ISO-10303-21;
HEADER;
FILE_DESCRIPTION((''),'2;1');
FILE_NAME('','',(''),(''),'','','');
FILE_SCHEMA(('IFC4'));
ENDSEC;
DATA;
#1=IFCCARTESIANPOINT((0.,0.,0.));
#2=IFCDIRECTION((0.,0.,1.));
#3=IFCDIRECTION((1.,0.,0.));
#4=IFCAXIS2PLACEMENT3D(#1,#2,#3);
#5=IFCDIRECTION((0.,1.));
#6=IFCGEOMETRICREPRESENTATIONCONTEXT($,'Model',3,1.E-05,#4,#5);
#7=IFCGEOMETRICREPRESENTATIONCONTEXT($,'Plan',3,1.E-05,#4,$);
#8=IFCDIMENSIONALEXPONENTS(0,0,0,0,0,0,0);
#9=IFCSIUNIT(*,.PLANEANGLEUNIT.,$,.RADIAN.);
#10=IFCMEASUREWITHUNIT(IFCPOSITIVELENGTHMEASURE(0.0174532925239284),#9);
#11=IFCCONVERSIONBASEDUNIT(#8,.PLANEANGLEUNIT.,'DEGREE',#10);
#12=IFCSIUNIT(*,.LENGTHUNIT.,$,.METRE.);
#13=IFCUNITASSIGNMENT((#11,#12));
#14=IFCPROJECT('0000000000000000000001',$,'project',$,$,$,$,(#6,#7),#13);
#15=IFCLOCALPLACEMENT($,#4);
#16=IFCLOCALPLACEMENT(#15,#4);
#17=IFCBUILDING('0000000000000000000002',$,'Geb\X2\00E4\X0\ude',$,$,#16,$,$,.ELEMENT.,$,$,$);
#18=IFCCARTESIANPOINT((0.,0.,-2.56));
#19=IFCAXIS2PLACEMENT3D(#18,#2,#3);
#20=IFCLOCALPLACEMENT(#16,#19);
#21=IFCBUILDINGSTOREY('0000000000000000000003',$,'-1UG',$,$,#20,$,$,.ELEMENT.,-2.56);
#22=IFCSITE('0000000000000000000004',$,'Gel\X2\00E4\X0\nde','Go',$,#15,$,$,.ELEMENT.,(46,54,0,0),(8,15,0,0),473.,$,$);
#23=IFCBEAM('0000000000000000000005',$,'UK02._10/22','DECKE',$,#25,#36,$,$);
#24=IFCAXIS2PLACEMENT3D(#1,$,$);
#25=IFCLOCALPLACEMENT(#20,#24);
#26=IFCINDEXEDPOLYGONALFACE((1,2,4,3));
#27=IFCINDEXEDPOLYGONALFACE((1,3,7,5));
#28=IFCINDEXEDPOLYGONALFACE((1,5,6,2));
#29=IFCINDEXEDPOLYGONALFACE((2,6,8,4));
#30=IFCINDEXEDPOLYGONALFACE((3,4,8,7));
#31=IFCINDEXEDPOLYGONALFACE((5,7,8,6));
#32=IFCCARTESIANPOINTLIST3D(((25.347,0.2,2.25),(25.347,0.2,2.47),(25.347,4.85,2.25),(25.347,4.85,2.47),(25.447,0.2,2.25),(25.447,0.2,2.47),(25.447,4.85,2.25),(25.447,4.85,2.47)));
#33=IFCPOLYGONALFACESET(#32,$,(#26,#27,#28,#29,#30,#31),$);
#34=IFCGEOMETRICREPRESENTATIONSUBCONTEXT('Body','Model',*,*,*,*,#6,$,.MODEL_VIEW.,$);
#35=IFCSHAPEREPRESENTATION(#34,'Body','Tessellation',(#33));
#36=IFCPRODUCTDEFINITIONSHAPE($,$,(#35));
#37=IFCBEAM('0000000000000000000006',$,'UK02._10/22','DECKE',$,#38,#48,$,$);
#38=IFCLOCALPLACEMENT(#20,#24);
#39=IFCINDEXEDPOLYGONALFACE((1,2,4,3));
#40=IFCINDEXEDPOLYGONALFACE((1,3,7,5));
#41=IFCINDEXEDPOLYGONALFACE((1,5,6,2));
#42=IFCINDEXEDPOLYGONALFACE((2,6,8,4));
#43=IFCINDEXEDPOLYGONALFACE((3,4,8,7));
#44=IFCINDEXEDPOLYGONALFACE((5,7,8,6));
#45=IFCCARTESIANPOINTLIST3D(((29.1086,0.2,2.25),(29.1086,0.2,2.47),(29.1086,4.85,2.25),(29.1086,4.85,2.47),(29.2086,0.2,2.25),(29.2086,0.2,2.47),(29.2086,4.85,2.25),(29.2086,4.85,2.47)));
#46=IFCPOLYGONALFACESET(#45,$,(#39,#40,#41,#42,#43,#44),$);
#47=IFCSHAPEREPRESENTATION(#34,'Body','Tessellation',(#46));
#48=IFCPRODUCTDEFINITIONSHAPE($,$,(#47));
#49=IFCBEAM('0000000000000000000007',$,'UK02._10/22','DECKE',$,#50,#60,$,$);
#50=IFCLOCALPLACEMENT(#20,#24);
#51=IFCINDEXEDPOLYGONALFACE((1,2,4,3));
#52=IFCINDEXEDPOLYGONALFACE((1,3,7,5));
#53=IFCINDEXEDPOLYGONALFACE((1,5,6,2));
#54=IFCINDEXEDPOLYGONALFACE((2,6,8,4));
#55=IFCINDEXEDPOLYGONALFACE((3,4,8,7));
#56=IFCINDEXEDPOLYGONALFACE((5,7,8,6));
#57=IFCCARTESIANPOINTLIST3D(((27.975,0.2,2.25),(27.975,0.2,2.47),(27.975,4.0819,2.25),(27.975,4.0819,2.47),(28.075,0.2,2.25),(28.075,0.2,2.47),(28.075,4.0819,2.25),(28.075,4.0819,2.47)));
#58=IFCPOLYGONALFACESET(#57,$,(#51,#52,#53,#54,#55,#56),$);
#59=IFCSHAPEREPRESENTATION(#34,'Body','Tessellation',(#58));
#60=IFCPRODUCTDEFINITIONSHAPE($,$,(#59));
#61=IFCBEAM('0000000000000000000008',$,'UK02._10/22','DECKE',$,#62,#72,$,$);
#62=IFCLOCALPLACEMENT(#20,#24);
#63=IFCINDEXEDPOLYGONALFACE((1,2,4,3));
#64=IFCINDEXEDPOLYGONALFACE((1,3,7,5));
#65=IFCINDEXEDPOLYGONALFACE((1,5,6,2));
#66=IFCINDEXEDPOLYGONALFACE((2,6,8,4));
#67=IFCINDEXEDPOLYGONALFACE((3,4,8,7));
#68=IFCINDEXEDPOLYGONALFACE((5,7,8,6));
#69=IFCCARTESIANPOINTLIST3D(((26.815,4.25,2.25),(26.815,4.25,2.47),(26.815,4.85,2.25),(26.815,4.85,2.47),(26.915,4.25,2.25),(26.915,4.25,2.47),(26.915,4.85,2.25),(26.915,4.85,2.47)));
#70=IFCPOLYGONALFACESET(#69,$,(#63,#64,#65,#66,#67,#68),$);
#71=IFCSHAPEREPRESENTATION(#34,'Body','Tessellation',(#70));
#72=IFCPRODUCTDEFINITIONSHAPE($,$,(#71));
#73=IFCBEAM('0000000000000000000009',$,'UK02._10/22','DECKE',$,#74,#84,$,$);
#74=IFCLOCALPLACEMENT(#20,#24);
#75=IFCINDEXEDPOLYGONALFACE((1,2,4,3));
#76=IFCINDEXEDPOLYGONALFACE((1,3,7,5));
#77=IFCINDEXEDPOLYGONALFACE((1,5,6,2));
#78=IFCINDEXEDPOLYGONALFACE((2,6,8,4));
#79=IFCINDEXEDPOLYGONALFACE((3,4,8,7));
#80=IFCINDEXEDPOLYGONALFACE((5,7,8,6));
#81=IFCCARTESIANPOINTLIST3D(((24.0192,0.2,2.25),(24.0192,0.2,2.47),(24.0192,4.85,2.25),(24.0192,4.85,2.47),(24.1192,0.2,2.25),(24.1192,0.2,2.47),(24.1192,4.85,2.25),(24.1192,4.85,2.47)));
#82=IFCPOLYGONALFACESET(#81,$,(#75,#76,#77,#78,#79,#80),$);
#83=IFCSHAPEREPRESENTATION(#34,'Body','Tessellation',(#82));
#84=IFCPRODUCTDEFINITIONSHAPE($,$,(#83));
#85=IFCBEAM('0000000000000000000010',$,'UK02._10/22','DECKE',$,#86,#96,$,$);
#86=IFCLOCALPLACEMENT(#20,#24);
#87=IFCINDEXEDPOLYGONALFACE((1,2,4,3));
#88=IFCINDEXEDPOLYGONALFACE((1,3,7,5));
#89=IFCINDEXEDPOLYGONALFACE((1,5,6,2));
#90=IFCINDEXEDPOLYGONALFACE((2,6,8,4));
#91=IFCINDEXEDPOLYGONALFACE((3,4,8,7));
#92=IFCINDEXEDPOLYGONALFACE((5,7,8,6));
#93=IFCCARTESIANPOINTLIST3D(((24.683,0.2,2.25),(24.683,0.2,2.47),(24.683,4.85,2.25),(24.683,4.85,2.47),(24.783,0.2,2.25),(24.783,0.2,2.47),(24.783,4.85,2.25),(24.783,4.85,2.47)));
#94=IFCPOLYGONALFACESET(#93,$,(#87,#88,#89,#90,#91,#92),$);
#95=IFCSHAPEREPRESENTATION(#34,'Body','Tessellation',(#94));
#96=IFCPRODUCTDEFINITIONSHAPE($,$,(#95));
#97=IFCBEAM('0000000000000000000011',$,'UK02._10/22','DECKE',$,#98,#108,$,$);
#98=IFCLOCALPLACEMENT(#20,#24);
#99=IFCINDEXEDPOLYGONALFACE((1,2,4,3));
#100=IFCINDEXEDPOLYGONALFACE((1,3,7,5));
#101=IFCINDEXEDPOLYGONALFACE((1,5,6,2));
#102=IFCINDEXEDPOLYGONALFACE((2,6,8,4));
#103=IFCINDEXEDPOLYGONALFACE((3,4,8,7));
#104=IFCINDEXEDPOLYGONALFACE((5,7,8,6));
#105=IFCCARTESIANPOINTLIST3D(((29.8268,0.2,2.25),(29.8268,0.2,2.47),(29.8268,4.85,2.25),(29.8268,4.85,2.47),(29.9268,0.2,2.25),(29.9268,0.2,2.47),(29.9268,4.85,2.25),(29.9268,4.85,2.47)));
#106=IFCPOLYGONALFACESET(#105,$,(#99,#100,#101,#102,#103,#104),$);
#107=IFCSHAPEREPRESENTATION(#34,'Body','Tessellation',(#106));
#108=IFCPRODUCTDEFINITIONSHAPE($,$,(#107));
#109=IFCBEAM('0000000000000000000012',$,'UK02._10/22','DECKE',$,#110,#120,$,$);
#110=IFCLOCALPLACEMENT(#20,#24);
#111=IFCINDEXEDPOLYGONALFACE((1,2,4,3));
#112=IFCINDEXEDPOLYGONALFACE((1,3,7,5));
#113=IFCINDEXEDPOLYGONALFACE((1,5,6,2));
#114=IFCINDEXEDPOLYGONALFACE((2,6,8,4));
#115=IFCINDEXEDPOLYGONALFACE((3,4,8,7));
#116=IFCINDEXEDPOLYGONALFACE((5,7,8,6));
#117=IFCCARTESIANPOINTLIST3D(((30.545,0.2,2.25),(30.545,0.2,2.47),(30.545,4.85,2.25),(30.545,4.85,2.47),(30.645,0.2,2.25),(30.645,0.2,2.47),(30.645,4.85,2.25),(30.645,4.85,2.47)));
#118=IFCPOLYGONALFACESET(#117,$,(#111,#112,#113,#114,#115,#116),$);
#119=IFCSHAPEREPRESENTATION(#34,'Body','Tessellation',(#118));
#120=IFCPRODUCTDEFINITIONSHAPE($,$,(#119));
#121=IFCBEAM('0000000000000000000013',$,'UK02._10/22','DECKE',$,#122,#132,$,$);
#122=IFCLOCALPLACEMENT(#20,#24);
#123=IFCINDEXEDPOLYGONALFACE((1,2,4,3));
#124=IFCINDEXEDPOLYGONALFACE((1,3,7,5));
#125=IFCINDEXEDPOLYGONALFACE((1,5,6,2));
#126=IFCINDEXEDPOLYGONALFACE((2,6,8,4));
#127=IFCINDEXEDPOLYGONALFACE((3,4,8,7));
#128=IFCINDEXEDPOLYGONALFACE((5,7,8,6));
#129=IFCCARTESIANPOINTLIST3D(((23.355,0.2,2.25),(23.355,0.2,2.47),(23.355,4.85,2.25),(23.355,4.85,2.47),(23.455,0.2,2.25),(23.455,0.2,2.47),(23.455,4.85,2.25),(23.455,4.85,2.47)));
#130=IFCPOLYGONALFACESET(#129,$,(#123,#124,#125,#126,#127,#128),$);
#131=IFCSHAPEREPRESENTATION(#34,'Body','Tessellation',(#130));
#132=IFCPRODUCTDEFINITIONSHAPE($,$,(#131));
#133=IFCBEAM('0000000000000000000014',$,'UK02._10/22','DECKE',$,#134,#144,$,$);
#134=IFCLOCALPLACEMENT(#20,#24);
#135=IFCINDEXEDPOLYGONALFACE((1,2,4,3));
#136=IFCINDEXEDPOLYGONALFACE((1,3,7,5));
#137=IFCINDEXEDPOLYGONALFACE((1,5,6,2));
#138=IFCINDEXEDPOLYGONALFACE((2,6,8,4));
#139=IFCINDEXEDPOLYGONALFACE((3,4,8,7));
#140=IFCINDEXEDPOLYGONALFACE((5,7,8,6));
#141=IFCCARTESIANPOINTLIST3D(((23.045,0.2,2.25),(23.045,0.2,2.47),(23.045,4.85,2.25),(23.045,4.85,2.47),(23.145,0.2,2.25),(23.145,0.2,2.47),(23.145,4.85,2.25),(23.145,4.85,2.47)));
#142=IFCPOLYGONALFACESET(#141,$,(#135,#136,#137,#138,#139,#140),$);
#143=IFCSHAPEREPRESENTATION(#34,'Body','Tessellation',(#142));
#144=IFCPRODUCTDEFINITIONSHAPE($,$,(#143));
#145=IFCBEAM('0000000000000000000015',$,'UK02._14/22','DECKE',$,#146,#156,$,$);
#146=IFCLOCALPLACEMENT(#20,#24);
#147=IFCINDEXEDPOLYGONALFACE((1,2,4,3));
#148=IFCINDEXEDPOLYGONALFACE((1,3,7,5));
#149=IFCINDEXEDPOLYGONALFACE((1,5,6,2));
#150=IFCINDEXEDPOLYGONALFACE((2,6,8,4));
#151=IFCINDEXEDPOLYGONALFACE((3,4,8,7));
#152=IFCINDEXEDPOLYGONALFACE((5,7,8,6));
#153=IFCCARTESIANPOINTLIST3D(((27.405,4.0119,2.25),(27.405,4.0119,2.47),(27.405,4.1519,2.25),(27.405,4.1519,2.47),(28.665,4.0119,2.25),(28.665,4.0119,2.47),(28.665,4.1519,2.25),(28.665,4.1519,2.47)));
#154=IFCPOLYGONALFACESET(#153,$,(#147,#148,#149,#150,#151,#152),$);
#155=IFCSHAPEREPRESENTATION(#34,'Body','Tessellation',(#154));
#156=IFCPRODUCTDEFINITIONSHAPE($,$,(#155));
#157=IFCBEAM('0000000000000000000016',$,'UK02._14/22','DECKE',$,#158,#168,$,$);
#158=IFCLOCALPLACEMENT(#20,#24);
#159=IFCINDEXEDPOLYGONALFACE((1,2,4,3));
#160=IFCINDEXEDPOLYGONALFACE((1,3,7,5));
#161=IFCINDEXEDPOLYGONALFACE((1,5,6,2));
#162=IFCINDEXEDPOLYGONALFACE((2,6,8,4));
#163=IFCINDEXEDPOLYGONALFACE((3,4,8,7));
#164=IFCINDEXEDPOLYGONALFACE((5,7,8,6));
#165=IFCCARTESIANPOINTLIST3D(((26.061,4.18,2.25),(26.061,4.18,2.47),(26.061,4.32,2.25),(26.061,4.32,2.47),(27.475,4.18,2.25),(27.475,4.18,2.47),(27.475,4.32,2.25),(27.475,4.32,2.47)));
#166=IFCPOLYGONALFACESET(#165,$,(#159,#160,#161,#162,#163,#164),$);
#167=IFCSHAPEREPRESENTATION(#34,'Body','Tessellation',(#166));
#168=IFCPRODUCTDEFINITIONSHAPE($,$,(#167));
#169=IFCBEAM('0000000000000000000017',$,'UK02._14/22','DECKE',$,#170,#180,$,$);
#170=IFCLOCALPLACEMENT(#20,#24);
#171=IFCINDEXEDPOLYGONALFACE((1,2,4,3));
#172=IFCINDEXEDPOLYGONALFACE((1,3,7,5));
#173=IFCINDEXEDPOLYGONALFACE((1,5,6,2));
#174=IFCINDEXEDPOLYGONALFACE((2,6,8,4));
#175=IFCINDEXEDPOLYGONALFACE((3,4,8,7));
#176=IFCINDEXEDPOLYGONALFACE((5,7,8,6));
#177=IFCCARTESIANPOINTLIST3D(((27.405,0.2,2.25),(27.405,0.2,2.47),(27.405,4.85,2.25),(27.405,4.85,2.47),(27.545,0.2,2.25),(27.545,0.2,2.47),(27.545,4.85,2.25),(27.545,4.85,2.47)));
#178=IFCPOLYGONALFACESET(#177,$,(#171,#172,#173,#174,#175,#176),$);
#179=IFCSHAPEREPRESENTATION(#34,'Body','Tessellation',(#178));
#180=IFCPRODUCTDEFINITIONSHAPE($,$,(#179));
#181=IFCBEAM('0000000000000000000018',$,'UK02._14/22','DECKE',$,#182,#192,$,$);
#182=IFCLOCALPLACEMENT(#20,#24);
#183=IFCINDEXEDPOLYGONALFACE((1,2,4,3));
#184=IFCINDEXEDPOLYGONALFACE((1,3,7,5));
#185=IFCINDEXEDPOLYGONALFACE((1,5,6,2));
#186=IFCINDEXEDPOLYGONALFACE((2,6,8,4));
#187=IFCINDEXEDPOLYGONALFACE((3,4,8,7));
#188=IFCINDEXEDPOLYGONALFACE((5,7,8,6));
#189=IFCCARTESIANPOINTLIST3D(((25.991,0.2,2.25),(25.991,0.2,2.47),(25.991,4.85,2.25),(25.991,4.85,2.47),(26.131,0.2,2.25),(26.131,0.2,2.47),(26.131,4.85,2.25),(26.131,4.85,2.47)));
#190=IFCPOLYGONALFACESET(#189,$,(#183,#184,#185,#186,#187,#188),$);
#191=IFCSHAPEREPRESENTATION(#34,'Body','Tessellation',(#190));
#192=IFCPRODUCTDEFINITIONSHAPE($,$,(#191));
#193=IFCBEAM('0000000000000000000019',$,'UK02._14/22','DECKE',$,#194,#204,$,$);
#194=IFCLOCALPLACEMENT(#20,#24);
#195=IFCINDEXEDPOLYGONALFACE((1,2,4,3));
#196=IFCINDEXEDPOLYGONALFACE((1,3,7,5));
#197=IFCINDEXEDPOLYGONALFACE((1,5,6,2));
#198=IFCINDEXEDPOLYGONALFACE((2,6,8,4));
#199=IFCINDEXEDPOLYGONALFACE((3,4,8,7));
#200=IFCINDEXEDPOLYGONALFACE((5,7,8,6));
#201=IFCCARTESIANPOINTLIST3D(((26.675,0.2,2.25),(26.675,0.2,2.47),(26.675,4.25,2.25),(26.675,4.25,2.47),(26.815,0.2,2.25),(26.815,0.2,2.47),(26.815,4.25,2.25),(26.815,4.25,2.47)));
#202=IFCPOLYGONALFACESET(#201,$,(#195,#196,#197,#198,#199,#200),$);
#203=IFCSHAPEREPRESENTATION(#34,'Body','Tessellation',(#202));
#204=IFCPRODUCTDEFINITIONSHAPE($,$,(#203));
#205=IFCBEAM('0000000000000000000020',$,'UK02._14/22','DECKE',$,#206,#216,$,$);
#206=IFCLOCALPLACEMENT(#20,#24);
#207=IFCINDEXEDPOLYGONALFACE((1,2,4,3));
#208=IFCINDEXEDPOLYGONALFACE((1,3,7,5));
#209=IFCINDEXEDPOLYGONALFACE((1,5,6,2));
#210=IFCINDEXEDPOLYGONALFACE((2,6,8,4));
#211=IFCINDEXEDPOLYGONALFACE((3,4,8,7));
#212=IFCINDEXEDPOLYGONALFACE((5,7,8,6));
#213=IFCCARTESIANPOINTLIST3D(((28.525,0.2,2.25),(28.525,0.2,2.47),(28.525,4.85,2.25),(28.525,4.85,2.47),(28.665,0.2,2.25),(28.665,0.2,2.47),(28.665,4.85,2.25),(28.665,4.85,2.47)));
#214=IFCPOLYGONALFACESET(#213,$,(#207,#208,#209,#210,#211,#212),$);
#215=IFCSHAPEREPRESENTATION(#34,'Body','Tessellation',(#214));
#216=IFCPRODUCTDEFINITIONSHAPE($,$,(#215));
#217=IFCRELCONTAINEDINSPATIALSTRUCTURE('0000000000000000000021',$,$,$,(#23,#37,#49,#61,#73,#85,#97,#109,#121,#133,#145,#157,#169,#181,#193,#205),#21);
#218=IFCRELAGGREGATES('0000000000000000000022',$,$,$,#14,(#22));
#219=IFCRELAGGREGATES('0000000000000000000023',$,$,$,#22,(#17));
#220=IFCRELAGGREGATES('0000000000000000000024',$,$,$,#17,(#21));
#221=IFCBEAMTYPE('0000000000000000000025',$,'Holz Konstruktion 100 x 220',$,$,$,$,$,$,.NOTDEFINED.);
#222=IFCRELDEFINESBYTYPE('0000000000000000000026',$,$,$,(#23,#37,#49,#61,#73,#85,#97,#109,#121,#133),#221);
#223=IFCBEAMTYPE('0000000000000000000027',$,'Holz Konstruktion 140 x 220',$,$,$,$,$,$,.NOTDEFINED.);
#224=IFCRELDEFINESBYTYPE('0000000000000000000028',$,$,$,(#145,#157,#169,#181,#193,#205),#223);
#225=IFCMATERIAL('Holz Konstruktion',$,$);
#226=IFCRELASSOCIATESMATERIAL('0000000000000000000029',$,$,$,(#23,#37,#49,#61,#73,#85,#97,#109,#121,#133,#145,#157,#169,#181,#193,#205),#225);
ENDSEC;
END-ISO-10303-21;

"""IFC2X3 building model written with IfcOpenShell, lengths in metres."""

from ifc_helpers import new_model, entity, si_unit, converted_unit, direction, frame, frame_2d, origin_with_axes, place, context, subcontext, project, spatial, rectangle, extrude, material, type_object, element, save


model = new_model("IFC2X3")

# Units and contexts
model_context = context("Model", 3, precision=1e-05, world=origin_with_axes(), true_north=direction((0.0, 1.0)))
plan_context = context("Plan", 3, precision=1e-05, world=origin_with_axes())
body_context = subcontext(model_context, "Body", "Model", "MODEL_VIEW")
ifc_project = project(units=[converted_unit("PLANEANGLEUNIT", "DEGREE", entity("IfcPositiveLengthMeasure", 0.0174532925239284), si_unit("PLANEANGLEUNIT", "RADIAN"), dimensions=[0, 0, 0, 0, 0, 0, 0]), si_unit("LENGTHUNIT", "METRE")], contexts=[model_context, plan_context])

# Site, building, storey
site_placement = place(None, origin_with_axes())
site = spatial("IfcSite", under=ifc_project, at=site_placement, Name="Gelände", Description="Go", CompositionType="ELEMENT", RefLatitude=(46, 54, 0, 0), RefLongitude=(8, 15, 0, 0), RefElevation=473.0)
building_placement = place(site_placement, origin_with_axes())
building = spatial("IfcBuilding", under=site, at=building_placement, Name="Gebäude", CompositionType="ELEMENT")
storey_placement = place(building_placement, frame((0.0, 0.0, -2.56), z_axis=(0.0, 0.0, 1.0), x_axis=(1.0, 0.0, 0.0)))
storey = spatial("IfcBuildingStorey", under=building, at=storey_placement, Name="-1UG", CompositionType="ELEMENT", Elevation=-2.56)

# Beams
ifc_material_1 = material(Name="Holz Konstruktion")
beam_type_1 = type_object("IfcBeamType", Name="Holz Konstruktion 100 x 220", PredefinedType="NOTDEFINED")
for number, where, z_axis, x_axis, name in (
    (1, (25.397, 0.2, 2.47), (0.0, 0.0, 1.0), (1.0, 0.0, 0.0), "UK02._10/22"),
    (2, (29.1586, 0.2, 2.47), (0.0, 0.0, 1.0), (1.0, 0.0, 0.0), "UK02._10/22"),
):
    element("IfcBeam", number, at=place(storey_placement, frame(where, z_axis=z_axis, x_axis=x_axis)), inside=storey, type_object=beam_type_1, material=ifc_material_1, Name=name, Description="DECKE", context=body_context, shape_type="SweptSolid", body=[
        extrude(rectangle(XDim=0.22, YDim=0.1, at=frame_2d((-0.11, 0.0), x_axis=(1.0, 0.0))), frame((0.0, 0.0, 0.0), z_axis=(0.0, 1.0, 0.0), x_axis=(0.0, 0.0, 1.0)), (0.0, 0.0, 1.0), 4.65),
    ])
beam_1_placement = place(storey_placement, frame((28.025, 0.2, 2.47), z_axis=(0.0, 0.0, 1.0), x_axis=(1.0, 0.0, 0.0)))
element("IfcBeam", 3, at=beam_1_placement, inside=storey, type_object=beam_type_1, material=ifc_material_1, Name="UK02._10/22", Description="DECKE", context=body_context, shape_type="SweptSolid", body=[
    extrude(rectangle(XDim=0.22, YDim=0.1, at=frame_2d((-0.11, 0.0), x_axis=(1.0, 0.0))), frame((0.0, 0.0, 0.0), z_axis=(0.0, 1.0, 0.0), x_axis=(0.0, 0.0, 1.0)), (0.0, 0.0, 1.0), 3.8819),
])
beam_2_placement = place(storey_placement, frame((26.865, 4.25, 2.47), z_axis=(0.0, 0.0, 1.0), x_axis=(1.0, 0.0, 0.0)))
element("IfcBeam", 4, at=beam_2_placement, inside=storey, type_object=beam_type_1, material=ifc_material_1, Name="UK02._10/22", Description="DECKE", context=body_context, shape_type="SweptSolid", body=[
    extrude(rectangle(XDim=0.22, YDim=0.1, at=frame_2d((-0.11, 0.0), x_axis=(1.0, 0.0))), frame((0.0, 0.0, 0.0), z_axis=(0.0, 1.0, 0.0), x_axis=(0.0, 0.0, 1.0)), (0.0, 0.0, 1.0), 0.6),
])
for number, where, z_axis, x_axis, name in (
    (5, (24.0692, 0.2, 2.47), (0.0, 0.0, 1.0), (1.0, 0.0, 0.0), "UK02._10/22"),
    (6, (24.733, 0.2, 2.47), (0.0, 0.0, 1.0), (1.0, 0.0, 0.0), "UK02._10/22"),
    (7, (29.8768, 0.2, 2.47), (0.0, 0.0, 1.0), (1.0, 0.0, 0.0), "UK02._10/22"),
    (8, (30.595, 0.2, 2.47), (0.0, 0.0, 1.0), (1.0, 0.0, 0.0), "UK02._10/22"),
    (9, (23.405, 0.2, 2.47), (0.0, 0.0, 1.0), (1.0, 0.0, 0.0), "UK02._10/22"),
    (10, (23.095, 0.2, 2.47), (0.0, 0.0, 1.0), (1.0, 0.0, 0.0), "UK02._10/22"),
):
    element("IfcBeam", number, at=place(storey_placement, frame(where, z_axis=z_axis, x_axis=x_axis)), inside=storey, type_object=beam_type_1, material=ifc_material_1, Name=name, Description="DECKE", context=body_context, shape_type="SweptSolid", body=[
        extrude(rectangle(XDim=0.22, YDim=0.1, at=frame_2d((-0.11, 0.0), x_axis=(1.0, 0.0))), frame((0.0, 0.0, 0.0), z_axis=(0.0, 1.0, 0.0), x_axis=(0.0, 0.0, 1.0)), (0.0, 0.0, 1.0), 4.65),
    ])
beam_type_2 = type_object("IfcBeamType", Name="Holz Konstruktion 140 x 220", PredefinedType="NOTDEFINED")
beam_3_placement = place(storey_placement, frame((28.665, 4.0819, 2.47), z_axis=(0.0, 0.0, 1.0), x_axis=(0.0, 1.0, 0.0)))
element("IfcBeam", 11, at=beam_3_placement, inside=storey, type_object=beam_type_2, material=ifc_material_1, Name="UK02._14/22", Description="DECKE", context=body_context, shape_type="SweptSolid", body=[
    extrude(rectangle(XDim=0.22, YDim=0.14, at=frame_2d((-0.11, 0.0), x_axis=(1.0, 0.0))), frame((0.0, 0.0, 0.0), z_axis=(0.0, 1.0, 0.0), x_axis=(0.0, 0.0, 1.0)), (0.0, 0.0, 1.0), 1.26),
])
beam_4_placement = place(storey_placement, frame((27.475, 4.25, 2.47), z_axis=(0.0, 0.0, 1.0), x_axis=(0.0, 1.0, 0.0)))
element("IfcBeam", 12, at=beam_4_placement, inside=storey, type_object=beam_type_2, material=ifc_material_1, Name="UK02._14/22", Description="DECKE", context=body_context, shape_type="SweptSolid", body=[
    extrude(rectangle(XDim=0.22, YDim=0.14, at=frame_2d((-0.11, 0.0), x_axis=(1.0, 0.0))), frame((0.0, 0.0, 0.0), z_axis=(0.0, 1.0, 0.0), x_axis=(0.0, 0.0, 1.0)), (0.0, 0.0, 1.0), 1.414),
])
for number, where, z_axis, x_axis, name in (
    (13, (27.475, 0.2, 2.47), (0.0, 0.0, 1.0), (1.0, 0.0, 0.0), "UK02._14/22"),
    (14, (26.061, 0.2, 2.47), (0.0, 0.0, 1.0), (1.0, 0.0, 0.0), "UK02._14/22"),
):
    element("IfcBeam", number, at=place(storey_placement, frame(where, z_axis=z_axis, x_axis=x_axis)), inside=storey, type_object=beam_type_2, material=ifc_material_1, Name=name, Description="DECKE", context=body_context, shape_type="SweptSolid", body=[
        extrude(rectangle(XDim=0.22, YDim=0.14, at=frame_2d((-0.11, 0.0), x_axis=(1.0, 0.0))), frame((0.0, 0.0, 0.0), z_axis=(0.0, 1.0, 0.0), x_axis=(0.0, 0.0, 1.0)), (0.0, 0.0, 1.0), 4.65),
    ])
beam_5_placement = place(storey_placement, frame((26.745, 0.2, 2.47), z_axis=(0.0, 0.0, 1.0), x_axis=(1.0, 0.0, 0.0)))
element("IfcBeam", 15, at=beam_5_placement, inside=storey, type_object=beam_type_2, material=ifc_material_1, Name="UK02._14/22", Description="DECKE", context=body_context, shape_type="SweptSolid", body=[
    extrude(rectangle(XDim=0.22, YDim=0.14, at=frame_2d((-0.11, 0.0), x_axis=(1.0, 0.0))), frame((0.0, 0.0, 0.0), z_axis=(0.0, 1.0, 0.0), x_axis=(0.0, 0.0, 1.0)), (0.0, 0.0, 1.0), 4.05),
])
beam_6_placement = place(storey_placement, frame((28.595, 0.2, 2.47), z_axis=(0.0, 0.0, 1.0), x_axis=(1.0, 0.0, 0.0)))
element("IfcBeam", 16, at=beam_6_placement, inside=storey, type_object=beam_type_2, material=ifc_material_1, Name="UK02._14/22", Description="DECKE", context=body_context, shape_type="SweptSolid", body=[
    extrude(rectangle(XDim=0.22, YDim=0.14, at=frame_2d((-0.11, 0.0), x_axis=(1.0, 0.0))), frame((0.0, 0.0, 0.0), z_axis=(0.0, 1.0, 0.0), x_axis=(0.0, 0.0, 1.0)), (0.0, 0.0, 1.0), 4.65),
])

save(model, "model.ifc")
